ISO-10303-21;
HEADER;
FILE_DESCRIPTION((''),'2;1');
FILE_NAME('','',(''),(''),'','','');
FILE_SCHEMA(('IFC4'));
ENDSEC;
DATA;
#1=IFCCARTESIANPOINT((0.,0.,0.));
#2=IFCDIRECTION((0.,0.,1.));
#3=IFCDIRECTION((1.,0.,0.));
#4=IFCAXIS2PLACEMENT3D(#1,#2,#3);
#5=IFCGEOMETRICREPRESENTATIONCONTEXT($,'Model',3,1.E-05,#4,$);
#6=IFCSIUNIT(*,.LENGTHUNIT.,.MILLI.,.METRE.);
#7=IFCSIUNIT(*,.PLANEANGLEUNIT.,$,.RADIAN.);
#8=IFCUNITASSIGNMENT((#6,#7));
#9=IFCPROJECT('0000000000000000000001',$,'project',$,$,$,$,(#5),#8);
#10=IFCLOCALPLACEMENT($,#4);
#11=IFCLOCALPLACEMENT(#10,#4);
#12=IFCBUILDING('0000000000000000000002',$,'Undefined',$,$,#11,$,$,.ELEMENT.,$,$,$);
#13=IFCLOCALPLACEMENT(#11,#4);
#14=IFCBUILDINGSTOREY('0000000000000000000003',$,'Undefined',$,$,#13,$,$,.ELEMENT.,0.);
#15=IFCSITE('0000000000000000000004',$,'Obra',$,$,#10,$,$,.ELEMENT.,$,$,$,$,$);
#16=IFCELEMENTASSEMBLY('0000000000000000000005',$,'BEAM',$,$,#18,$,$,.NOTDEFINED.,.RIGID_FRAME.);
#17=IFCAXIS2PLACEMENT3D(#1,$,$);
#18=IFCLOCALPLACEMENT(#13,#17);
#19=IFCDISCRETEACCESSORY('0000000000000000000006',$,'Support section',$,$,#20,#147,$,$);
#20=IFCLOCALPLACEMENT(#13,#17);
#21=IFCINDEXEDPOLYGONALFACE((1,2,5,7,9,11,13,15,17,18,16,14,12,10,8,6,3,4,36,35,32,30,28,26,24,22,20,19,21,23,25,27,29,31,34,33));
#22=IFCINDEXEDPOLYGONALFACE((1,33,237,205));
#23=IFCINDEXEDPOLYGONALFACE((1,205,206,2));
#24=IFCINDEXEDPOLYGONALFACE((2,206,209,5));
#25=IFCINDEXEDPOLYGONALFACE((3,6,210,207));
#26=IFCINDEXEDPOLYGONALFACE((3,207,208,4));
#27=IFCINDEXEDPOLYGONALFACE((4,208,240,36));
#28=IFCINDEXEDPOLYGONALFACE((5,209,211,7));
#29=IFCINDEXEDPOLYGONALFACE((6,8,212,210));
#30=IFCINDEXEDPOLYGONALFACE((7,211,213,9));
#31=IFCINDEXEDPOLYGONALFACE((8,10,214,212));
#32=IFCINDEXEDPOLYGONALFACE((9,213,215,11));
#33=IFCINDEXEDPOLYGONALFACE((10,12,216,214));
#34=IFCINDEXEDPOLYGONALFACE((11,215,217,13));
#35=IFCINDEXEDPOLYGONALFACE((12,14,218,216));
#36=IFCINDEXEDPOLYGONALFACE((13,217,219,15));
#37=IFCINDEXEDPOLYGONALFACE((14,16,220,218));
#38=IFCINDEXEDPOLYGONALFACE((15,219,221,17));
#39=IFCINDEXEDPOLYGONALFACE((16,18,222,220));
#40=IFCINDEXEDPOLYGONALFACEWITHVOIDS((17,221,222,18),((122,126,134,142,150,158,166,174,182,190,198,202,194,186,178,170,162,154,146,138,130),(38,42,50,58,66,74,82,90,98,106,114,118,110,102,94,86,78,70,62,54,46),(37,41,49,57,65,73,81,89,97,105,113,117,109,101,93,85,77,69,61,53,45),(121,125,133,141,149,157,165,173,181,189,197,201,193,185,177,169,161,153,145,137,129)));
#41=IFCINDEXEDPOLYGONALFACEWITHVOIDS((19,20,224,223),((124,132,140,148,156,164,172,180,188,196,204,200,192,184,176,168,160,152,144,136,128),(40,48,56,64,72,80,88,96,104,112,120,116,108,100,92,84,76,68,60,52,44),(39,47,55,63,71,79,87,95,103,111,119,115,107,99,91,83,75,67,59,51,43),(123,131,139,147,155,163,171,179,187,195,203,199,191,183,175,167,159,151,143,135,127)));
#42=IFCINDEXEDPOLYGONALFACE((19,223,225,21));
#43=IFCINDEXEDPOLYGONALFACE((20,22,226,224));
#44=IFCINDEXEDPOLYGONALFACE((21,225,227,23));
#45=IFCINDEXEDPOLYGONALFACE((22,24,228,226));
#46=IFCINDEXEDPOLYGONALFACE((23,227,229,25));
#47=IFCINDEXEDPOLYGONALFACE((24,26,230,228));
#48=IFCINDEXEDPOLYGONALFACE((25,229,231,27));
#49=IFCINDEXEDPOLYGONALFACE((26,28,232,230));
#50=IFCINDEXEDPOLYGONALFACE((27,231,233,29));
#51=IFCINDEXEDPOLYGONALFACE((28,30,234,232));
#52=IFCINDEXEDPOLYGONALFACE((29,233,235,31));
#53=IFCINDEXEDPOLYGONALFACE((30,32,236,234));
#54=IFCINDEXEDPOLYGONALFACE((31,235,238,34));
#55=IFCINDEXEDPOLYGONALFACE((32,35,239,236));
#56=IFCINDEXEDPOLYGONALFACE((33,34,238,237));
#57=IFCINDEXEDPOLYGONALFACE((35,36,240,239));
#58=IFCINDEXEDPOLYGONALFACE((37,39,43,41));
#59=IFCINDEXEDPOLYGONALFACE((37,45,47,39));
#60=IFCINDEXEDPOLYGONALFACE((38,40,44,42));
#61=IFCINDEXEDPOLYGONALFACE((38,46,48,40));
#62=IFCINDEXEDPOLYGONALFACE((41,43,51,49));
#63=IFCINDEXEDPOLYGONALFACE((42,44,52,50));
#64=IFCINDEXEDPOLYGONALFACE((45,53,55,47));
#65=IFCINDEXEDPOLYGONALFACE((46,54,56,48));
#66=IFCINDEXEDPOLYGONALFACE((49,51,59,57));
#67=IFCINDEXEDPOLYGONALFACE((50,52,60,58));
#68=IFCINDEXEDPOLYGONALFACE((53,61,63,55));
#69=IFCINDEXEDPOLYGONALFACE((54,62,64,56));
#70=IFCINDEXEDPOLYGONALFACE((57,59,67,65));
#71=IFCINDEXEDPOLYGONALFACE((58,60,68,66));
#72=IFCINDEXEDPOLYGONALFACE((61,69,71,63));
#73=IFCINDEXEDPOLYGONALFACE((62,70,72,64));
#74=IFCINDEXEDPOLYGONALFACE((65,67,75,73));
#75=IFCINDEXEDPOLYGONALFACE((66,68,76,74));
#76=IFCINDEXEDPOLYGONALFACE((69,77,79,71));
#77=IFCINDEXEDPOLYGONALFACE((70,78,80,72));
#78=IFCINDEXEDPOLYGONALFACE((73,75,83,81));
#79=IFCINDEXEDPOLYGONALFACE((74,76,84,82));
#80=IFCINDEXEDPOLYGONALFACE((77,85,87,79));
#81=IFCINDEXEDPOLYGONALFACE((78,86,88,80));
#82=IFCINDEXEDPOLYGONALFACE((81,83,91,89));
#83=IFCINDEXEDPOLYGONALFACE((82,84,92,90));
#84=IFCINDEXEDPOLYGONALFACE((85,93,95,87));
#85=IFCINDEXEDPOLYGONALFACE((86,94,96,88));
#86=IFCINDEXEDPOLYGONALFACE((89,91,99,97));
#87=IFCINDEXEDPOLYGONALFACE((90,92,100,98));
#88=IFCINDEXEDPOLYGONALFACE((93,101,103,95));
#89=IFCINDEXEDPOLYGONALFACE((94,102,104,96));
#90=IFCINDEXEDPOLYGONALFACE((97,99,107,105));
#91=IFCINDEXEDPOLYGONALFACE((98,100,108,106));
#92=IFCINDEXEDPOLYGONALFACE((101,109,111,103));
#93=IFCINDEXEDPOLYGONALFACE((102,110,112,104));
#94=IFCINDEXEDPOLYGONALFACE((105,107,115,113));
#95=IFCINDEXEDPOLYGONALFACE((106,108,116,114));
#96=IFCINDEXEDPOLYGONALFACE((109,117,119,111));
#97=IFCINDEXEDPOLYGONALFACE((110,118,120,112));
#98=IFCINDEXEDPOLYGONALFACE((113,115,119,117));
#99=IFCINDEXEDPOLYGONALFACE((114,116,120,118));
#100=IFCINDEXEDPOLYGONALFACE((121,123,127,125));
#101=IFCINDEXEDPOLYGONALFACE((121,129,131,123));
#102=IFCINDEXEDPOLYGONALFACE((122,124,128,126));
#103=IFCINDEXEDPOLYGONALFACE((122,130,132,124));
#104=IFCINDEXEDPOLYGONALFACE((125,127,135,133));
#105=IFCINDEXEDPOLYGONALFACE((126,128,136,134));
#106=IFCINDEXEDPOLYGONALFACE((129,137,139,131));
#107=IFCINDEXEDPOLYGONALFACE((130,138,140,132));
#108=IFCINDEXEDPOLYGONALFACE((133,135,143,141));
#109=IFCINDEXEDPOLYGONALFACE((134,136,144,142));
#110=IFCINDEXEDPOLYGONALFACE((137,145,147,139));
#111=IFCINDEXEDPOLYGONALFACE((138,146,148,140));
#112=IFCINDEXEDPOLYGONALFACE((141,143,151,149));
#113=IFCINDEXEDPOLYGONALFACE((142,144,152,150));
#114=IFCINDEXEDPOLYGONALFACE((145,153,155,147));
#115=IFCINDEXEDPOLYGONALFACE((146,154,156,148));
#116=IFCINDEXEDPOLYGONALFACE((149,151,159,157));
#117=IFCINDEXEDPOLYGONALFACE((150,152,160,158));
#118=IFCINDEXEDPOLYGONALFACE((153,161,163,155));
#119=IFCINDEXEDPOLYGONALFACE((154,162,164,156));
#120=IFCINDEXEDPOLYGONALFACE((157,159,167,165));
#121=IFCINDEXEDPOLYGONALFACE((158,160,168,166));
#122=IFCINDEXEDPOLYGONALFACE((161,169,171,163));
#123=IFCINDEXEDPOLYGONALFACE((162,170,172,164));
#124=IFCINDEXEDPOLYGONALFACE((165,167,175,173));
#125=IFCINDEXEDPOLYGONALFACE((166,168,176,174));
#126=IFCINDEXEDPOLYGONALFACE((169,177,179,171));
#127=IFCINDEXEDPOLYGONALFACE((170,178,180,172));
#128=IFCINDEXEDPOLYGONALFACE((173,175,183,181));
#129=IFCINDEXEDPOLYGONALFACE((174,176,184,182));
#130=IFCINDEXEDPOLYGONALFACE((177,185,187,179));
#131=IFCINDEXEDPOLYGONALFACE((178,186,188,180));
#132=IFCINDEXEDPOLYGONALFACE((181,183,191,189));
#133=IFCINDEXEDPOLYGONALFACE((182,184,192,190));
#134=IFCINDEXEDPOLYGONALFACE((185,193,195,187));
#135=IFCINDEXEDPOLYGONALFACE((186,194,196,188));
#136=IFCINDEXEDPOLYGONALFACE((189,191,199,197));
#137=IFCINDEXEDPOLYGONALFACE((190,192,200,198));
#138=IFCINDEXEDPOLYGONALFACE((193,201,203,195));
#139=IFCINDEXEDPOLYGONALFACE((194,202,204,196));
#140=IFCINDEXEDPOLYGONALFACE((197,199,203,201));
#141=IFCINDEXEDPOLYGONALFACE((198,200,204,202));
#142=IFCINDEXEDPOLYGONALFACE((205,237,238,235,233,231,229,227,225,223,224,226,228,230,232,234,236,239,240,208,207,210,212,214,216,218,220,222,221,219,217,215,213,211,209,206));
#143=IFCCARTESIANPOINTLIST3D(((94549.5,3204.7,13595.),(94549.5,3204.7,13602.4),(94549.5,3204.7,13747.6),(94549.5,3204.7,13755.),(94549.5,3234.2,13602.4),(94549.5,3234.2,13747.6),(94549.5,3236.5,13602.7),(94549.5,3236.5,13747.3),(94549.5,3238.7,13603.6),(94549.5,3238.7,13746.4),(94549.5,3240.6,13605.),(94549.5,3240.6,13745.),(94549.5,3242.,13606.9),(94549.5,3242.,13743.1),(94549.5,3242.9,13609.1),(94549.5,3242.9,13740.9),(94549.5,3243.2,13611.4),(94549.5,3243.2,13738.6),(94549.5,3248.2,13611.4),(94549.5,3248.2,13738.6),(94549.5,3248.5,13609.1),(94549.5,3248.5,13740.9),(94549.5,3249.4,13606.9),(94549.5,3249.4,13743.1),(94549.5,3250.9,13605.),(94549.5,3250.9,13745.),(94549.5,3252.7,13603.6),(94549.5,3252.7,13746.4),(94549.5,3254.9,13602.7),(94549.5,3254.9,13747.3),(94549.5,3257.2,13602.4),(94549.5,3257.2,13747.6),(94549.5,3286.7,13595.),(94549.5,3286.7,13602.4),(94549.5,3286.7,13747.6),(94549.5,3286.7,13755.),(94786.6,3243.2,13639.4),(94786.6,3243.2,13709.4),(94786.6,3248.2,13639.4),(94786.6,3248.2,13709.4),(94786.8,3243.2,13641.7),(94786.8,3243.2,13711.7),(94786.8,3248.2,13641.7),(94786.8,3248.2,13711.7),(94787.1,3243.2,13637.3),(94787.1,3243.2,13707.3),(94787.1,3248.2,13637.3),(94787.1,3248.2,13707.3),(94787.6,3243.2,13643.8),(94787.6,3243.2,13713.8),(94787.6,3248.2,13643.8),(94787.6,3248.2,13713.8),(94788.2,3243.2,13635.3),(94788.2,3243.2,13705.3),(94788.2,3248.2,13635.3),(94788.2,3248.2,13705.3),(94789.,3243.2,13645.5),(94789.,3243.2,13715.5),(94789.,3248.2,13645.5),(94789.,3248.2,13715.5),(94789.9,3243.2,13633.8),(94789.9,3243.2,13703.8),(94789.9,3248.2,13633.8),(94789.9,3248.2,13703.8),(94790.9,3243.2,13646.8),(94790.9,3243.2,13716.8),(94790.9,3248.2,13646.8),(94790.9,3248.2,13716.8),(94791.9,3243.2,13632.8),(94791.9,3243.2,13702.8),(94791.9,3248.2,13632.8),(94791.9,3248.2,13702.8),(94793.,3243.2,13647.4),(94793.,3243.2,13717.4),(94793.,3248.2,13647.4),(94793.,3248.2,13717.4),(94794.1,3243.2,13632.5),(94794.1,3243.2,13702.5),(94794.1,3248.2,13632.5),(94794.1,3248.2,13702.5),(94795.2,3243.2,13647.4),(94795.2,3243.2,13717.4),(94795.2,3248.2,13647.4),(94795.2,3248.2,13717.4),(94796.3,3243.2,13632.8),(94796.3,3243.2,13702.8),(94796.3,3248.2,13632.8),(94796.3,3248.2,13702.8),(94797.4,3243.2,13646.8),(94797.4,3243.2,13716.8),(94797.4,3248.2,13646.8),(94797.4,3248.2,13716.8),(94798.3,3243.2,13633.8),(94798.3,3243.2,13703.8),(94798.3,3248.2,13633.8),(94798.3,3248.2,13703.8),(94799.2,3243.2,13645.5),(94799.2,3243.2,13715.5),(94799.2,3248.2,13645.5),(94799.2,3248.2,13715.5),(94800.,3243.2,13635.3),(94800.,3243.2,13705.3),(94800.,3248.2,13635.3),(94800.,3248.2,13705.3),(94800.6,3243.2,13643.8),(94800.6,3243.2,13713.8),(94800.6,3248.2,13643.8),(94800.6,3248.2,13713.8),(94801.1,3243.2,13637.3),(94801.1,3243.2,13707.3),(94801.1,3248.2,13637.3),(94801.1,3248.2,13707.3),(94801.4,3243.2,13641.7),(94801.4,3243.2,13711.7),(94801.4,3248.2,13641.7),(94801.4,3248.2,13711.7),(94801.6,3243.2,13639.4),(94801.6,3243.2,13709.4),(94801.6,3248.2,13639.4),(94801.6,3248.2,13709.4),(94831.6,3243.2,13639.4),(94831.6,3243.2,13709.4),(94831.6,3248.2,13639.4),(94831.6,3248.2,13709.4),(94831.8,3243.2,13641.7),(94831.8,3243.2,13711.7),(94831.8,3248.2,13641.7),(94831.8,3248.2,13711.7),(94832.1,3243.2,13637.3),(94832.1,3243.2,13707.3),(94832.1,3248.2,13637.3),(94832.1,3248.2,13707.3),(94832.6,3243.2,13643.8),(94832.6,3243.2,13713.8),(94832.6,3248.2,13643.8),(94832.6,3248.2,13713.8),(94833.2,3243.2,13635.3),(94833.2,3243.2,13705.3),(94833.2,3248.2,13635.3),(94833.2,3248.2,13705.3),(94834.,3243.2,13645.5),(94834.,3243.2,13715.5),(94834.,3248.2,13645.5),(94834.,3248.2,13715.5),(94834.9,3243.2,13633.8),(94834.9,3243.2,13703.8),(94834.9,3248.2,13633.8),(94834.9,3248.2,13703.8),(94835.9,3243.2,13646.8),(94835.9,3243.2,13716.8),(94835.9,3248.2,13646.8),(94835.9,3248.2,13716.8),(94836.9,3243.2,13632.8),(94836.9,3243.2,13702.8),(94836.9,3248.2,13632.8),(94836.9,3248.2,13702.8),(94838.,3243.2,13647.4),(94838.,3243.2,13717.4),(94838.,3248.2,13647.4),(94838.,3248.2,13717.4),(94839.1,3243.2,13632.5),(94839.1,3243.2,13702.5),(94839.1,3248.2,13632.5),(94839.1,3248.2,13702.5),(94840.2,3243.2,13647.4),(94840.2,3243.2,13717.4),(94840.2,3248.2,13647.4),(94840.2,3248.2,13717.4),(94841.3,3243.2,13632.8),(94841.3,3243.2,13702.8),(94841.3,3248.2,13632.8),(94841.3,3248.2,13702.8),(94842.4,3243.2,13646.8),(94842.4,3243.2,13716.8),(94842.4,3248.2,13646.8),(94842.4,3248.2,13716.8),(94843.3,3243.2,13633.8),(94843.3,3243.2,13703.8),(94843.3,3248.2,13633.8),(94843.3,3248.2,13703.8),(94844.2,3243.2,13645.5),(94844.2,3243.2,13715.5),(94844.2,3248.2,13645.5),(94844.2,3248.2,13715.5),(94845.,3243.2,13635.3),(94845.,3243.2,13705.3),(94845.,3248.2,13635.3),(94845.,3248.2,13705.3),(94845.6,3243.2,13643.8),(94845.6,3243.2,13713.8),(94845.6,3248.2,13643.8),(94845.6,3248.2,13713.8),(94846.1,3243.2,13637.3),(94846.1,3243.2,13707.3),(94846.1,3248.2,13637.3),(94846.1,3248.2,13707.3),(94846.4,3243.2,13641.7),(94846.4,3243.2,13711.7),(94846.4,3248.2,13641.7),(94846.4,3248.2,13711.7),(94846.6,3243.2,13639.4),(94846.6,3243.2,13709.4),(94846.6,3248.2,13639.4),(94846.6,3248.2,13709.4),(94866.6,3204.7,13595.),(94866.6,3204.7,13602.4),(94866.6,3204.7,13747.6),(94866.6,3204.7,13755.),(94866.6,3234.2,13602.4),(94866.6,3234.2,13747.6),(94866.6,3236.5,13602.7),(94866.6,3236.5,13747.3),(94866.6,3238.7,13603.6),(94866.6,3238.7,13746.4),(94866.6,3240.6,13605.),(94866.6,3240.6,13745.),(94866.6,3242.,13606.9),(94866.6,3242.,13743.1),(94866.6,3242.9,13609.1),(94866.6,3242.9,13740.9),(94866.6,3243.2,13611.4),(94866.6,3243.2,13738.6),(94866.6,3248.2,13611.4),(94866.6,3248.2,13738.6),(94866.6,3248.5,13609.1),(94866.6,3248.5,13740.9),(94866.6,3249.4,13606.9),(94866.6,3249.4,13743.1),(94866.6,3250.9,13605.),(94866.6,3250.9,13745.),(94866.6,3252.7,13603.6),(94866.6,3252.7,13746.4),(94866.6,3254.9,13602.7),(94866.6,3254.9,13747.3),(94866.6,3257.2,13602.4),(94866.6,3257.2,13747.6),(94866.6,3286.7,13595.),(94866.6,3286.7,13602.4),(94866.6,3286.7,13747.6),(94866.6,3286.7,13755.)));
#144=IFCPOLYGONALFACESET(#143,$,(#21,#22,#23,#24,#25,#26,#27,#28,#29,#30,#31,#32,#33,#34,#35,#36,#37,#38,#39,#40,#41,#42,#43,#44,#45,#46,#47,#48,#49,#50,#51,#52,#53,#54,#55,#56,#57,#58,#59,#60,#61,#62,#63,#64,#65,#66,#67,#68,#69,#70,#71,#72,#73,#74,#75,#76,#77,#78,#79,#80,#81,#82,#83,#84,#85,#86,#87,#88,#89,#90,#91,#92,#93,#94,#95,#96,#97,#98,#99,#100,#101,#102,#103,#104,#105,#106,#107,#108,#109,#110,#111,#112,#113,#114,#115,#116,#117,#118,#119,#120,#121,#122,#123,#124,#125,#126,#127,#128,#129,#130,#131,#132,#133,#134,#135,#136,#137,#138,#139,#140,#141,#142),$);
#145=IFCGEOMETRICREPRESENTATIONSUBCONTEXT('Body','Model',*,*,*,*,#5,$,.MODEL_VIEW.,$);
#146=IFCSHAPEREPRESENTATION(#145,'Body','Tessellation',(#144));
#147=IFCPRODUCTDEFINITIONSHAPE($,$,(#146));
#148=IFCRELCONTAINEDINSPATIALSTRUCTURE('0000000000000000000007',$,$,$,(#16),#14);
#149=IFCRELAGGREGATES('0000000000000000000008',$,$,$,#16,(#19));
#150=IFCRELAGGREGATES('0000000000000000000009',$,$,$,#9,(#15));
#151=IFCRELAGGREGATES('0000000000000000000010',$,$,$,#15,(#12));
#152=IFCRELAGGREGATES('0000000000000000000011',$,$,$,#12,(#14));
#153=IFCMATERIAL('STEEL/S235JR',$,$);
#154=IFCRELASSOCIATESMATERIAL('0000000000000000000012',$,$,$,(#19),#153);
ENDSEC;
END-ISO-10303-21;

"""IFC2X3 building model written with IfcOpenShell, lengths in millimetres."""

from ifc_helpers import new_model, si_unit, frame, origin_with_axes, origin_2d_with_axis, place, context, subcontext, project, spatial, circle, i_section, extrude, clip, halfspace, source, transform, mapped, material, element, aggregate, save


model = new_model("IFC2X3")

# Units and contexts
model_context = context("Model", 3, precision=1e-05, world=origin_with_axes())
body_context = subcontext(model_context, "Body", "Model", "MODEL_VIEW")
ifc_project = project(units=[si_unit("LENGTHUNIT", "METRE", prefix="MILLI"), si_unit("PLANEANGLEUNIT", "RADIAN")], contexts=[model_context])

# Site, building, storey
site_placement = place(None, origin_with_axes())
site = spatial("IfcSite", under=ifc_project, at=site_placement, Name="Obra", CompositionType="ELEMENT")
building_placement = place(site_placement, origin_with_axes())
building = spatial("IfcBuilding", under=site, at=building_placement, Name="Undefined", CompositionType="ELEMENT")
storey_placement = place(building_placement, origin_with_axes())
storey = spatial("IfcBuildingStorey", under=building, at=storey_placement, Name="Undefined", CompositionType="ELEMENT", Elevation=0.0)

# Shared definitions
ifc_material_1 = material(Name="STEEL/S235JR")

# Element assembly
assembly_1_placement = place(storey_placement, origin_with_axes())
assembly_1 = element("IfcElementAssembly", 1, at=assembly_1_placement, inside=storey, Name="BEAM", AssemblyPlace="NOTDEFINED", PredefinedType="RIGID_FRAME")

# Discrete accessory, opening
discrete_accessory_1_placement = place(assembly_1_placement, frame((94549.5, 3245.7, 13675.0), z_axis=(0.0, 0.0, 1.0), x_axis=(1.0, 0.0, 0.0)))
discrete_accessory_1 = element("IfcDiscreteAccessory", 2, at=discrete_accessory_1_placement, material=ifc_material_1, Name="Support section", context=body_context, shape_type="Clipping", body=[
    clip(extrude(i_section(OverallWidth=82.0, OverallDepth=160.0, WebThickness=5.0, FlangeThickness=7.4, FilletRadius=9.0, at=origin_2d_with_axis()), frame((317.1, 0.0, 0.0), z_axis=(-1.0, 0.0, 0.0), x_axis=(0.0, -1.0, 0.0)), (0.0, 0.0, 1.0), 317.1), halfspace(frame((317.1, 0.0, -180.0), z_axis=(-1.0, 0.0, 0.0), x_axis=(0.0, 1.0, 0.0)), True)),
])
shared_shape_1 = source(origin_with_axes(), body_context, "Body", "SweptSolid", [
    extrude(circle(Radius=7.5, at=origin_2d_with_axis()), frame((0.0, -2.6, 0.0), z_axis=(0.0, 1.0, 0.0), x_axis=(1.0, 0.0, 0.0)), (0.0, 0.0, 1.0), 5.2),
])
opening_1_placement = place(assembly_1_placement, frame((94816.6, 3245.7, 13710.0), z_axis=(-1.0, 0.0, 0.0), x_axis=(0.0, 0.0, -1.0)))
element("IfcOpeningElement", 3, at=opening_1_placement, cuts=discrete_accessory_1, ObjectType="Opening", context=body_context, shape_type="MappedRepresentation", body=[
    mapped(shared_shape_1, transform((0.0, 0.0, -22.5))),
    mapped(shared_shape_1, transform((70.0, 0.0, -22.5))),
    mapped(shared_shape_1, transform((0.0, 0.0, 22.5))),
    mapped(shared_shape_1, transform((70.0, 0.0, 22.5))),
])
aggregate(assembly_1, [discrete_accessory_1])

save(model, "model.ifc")
